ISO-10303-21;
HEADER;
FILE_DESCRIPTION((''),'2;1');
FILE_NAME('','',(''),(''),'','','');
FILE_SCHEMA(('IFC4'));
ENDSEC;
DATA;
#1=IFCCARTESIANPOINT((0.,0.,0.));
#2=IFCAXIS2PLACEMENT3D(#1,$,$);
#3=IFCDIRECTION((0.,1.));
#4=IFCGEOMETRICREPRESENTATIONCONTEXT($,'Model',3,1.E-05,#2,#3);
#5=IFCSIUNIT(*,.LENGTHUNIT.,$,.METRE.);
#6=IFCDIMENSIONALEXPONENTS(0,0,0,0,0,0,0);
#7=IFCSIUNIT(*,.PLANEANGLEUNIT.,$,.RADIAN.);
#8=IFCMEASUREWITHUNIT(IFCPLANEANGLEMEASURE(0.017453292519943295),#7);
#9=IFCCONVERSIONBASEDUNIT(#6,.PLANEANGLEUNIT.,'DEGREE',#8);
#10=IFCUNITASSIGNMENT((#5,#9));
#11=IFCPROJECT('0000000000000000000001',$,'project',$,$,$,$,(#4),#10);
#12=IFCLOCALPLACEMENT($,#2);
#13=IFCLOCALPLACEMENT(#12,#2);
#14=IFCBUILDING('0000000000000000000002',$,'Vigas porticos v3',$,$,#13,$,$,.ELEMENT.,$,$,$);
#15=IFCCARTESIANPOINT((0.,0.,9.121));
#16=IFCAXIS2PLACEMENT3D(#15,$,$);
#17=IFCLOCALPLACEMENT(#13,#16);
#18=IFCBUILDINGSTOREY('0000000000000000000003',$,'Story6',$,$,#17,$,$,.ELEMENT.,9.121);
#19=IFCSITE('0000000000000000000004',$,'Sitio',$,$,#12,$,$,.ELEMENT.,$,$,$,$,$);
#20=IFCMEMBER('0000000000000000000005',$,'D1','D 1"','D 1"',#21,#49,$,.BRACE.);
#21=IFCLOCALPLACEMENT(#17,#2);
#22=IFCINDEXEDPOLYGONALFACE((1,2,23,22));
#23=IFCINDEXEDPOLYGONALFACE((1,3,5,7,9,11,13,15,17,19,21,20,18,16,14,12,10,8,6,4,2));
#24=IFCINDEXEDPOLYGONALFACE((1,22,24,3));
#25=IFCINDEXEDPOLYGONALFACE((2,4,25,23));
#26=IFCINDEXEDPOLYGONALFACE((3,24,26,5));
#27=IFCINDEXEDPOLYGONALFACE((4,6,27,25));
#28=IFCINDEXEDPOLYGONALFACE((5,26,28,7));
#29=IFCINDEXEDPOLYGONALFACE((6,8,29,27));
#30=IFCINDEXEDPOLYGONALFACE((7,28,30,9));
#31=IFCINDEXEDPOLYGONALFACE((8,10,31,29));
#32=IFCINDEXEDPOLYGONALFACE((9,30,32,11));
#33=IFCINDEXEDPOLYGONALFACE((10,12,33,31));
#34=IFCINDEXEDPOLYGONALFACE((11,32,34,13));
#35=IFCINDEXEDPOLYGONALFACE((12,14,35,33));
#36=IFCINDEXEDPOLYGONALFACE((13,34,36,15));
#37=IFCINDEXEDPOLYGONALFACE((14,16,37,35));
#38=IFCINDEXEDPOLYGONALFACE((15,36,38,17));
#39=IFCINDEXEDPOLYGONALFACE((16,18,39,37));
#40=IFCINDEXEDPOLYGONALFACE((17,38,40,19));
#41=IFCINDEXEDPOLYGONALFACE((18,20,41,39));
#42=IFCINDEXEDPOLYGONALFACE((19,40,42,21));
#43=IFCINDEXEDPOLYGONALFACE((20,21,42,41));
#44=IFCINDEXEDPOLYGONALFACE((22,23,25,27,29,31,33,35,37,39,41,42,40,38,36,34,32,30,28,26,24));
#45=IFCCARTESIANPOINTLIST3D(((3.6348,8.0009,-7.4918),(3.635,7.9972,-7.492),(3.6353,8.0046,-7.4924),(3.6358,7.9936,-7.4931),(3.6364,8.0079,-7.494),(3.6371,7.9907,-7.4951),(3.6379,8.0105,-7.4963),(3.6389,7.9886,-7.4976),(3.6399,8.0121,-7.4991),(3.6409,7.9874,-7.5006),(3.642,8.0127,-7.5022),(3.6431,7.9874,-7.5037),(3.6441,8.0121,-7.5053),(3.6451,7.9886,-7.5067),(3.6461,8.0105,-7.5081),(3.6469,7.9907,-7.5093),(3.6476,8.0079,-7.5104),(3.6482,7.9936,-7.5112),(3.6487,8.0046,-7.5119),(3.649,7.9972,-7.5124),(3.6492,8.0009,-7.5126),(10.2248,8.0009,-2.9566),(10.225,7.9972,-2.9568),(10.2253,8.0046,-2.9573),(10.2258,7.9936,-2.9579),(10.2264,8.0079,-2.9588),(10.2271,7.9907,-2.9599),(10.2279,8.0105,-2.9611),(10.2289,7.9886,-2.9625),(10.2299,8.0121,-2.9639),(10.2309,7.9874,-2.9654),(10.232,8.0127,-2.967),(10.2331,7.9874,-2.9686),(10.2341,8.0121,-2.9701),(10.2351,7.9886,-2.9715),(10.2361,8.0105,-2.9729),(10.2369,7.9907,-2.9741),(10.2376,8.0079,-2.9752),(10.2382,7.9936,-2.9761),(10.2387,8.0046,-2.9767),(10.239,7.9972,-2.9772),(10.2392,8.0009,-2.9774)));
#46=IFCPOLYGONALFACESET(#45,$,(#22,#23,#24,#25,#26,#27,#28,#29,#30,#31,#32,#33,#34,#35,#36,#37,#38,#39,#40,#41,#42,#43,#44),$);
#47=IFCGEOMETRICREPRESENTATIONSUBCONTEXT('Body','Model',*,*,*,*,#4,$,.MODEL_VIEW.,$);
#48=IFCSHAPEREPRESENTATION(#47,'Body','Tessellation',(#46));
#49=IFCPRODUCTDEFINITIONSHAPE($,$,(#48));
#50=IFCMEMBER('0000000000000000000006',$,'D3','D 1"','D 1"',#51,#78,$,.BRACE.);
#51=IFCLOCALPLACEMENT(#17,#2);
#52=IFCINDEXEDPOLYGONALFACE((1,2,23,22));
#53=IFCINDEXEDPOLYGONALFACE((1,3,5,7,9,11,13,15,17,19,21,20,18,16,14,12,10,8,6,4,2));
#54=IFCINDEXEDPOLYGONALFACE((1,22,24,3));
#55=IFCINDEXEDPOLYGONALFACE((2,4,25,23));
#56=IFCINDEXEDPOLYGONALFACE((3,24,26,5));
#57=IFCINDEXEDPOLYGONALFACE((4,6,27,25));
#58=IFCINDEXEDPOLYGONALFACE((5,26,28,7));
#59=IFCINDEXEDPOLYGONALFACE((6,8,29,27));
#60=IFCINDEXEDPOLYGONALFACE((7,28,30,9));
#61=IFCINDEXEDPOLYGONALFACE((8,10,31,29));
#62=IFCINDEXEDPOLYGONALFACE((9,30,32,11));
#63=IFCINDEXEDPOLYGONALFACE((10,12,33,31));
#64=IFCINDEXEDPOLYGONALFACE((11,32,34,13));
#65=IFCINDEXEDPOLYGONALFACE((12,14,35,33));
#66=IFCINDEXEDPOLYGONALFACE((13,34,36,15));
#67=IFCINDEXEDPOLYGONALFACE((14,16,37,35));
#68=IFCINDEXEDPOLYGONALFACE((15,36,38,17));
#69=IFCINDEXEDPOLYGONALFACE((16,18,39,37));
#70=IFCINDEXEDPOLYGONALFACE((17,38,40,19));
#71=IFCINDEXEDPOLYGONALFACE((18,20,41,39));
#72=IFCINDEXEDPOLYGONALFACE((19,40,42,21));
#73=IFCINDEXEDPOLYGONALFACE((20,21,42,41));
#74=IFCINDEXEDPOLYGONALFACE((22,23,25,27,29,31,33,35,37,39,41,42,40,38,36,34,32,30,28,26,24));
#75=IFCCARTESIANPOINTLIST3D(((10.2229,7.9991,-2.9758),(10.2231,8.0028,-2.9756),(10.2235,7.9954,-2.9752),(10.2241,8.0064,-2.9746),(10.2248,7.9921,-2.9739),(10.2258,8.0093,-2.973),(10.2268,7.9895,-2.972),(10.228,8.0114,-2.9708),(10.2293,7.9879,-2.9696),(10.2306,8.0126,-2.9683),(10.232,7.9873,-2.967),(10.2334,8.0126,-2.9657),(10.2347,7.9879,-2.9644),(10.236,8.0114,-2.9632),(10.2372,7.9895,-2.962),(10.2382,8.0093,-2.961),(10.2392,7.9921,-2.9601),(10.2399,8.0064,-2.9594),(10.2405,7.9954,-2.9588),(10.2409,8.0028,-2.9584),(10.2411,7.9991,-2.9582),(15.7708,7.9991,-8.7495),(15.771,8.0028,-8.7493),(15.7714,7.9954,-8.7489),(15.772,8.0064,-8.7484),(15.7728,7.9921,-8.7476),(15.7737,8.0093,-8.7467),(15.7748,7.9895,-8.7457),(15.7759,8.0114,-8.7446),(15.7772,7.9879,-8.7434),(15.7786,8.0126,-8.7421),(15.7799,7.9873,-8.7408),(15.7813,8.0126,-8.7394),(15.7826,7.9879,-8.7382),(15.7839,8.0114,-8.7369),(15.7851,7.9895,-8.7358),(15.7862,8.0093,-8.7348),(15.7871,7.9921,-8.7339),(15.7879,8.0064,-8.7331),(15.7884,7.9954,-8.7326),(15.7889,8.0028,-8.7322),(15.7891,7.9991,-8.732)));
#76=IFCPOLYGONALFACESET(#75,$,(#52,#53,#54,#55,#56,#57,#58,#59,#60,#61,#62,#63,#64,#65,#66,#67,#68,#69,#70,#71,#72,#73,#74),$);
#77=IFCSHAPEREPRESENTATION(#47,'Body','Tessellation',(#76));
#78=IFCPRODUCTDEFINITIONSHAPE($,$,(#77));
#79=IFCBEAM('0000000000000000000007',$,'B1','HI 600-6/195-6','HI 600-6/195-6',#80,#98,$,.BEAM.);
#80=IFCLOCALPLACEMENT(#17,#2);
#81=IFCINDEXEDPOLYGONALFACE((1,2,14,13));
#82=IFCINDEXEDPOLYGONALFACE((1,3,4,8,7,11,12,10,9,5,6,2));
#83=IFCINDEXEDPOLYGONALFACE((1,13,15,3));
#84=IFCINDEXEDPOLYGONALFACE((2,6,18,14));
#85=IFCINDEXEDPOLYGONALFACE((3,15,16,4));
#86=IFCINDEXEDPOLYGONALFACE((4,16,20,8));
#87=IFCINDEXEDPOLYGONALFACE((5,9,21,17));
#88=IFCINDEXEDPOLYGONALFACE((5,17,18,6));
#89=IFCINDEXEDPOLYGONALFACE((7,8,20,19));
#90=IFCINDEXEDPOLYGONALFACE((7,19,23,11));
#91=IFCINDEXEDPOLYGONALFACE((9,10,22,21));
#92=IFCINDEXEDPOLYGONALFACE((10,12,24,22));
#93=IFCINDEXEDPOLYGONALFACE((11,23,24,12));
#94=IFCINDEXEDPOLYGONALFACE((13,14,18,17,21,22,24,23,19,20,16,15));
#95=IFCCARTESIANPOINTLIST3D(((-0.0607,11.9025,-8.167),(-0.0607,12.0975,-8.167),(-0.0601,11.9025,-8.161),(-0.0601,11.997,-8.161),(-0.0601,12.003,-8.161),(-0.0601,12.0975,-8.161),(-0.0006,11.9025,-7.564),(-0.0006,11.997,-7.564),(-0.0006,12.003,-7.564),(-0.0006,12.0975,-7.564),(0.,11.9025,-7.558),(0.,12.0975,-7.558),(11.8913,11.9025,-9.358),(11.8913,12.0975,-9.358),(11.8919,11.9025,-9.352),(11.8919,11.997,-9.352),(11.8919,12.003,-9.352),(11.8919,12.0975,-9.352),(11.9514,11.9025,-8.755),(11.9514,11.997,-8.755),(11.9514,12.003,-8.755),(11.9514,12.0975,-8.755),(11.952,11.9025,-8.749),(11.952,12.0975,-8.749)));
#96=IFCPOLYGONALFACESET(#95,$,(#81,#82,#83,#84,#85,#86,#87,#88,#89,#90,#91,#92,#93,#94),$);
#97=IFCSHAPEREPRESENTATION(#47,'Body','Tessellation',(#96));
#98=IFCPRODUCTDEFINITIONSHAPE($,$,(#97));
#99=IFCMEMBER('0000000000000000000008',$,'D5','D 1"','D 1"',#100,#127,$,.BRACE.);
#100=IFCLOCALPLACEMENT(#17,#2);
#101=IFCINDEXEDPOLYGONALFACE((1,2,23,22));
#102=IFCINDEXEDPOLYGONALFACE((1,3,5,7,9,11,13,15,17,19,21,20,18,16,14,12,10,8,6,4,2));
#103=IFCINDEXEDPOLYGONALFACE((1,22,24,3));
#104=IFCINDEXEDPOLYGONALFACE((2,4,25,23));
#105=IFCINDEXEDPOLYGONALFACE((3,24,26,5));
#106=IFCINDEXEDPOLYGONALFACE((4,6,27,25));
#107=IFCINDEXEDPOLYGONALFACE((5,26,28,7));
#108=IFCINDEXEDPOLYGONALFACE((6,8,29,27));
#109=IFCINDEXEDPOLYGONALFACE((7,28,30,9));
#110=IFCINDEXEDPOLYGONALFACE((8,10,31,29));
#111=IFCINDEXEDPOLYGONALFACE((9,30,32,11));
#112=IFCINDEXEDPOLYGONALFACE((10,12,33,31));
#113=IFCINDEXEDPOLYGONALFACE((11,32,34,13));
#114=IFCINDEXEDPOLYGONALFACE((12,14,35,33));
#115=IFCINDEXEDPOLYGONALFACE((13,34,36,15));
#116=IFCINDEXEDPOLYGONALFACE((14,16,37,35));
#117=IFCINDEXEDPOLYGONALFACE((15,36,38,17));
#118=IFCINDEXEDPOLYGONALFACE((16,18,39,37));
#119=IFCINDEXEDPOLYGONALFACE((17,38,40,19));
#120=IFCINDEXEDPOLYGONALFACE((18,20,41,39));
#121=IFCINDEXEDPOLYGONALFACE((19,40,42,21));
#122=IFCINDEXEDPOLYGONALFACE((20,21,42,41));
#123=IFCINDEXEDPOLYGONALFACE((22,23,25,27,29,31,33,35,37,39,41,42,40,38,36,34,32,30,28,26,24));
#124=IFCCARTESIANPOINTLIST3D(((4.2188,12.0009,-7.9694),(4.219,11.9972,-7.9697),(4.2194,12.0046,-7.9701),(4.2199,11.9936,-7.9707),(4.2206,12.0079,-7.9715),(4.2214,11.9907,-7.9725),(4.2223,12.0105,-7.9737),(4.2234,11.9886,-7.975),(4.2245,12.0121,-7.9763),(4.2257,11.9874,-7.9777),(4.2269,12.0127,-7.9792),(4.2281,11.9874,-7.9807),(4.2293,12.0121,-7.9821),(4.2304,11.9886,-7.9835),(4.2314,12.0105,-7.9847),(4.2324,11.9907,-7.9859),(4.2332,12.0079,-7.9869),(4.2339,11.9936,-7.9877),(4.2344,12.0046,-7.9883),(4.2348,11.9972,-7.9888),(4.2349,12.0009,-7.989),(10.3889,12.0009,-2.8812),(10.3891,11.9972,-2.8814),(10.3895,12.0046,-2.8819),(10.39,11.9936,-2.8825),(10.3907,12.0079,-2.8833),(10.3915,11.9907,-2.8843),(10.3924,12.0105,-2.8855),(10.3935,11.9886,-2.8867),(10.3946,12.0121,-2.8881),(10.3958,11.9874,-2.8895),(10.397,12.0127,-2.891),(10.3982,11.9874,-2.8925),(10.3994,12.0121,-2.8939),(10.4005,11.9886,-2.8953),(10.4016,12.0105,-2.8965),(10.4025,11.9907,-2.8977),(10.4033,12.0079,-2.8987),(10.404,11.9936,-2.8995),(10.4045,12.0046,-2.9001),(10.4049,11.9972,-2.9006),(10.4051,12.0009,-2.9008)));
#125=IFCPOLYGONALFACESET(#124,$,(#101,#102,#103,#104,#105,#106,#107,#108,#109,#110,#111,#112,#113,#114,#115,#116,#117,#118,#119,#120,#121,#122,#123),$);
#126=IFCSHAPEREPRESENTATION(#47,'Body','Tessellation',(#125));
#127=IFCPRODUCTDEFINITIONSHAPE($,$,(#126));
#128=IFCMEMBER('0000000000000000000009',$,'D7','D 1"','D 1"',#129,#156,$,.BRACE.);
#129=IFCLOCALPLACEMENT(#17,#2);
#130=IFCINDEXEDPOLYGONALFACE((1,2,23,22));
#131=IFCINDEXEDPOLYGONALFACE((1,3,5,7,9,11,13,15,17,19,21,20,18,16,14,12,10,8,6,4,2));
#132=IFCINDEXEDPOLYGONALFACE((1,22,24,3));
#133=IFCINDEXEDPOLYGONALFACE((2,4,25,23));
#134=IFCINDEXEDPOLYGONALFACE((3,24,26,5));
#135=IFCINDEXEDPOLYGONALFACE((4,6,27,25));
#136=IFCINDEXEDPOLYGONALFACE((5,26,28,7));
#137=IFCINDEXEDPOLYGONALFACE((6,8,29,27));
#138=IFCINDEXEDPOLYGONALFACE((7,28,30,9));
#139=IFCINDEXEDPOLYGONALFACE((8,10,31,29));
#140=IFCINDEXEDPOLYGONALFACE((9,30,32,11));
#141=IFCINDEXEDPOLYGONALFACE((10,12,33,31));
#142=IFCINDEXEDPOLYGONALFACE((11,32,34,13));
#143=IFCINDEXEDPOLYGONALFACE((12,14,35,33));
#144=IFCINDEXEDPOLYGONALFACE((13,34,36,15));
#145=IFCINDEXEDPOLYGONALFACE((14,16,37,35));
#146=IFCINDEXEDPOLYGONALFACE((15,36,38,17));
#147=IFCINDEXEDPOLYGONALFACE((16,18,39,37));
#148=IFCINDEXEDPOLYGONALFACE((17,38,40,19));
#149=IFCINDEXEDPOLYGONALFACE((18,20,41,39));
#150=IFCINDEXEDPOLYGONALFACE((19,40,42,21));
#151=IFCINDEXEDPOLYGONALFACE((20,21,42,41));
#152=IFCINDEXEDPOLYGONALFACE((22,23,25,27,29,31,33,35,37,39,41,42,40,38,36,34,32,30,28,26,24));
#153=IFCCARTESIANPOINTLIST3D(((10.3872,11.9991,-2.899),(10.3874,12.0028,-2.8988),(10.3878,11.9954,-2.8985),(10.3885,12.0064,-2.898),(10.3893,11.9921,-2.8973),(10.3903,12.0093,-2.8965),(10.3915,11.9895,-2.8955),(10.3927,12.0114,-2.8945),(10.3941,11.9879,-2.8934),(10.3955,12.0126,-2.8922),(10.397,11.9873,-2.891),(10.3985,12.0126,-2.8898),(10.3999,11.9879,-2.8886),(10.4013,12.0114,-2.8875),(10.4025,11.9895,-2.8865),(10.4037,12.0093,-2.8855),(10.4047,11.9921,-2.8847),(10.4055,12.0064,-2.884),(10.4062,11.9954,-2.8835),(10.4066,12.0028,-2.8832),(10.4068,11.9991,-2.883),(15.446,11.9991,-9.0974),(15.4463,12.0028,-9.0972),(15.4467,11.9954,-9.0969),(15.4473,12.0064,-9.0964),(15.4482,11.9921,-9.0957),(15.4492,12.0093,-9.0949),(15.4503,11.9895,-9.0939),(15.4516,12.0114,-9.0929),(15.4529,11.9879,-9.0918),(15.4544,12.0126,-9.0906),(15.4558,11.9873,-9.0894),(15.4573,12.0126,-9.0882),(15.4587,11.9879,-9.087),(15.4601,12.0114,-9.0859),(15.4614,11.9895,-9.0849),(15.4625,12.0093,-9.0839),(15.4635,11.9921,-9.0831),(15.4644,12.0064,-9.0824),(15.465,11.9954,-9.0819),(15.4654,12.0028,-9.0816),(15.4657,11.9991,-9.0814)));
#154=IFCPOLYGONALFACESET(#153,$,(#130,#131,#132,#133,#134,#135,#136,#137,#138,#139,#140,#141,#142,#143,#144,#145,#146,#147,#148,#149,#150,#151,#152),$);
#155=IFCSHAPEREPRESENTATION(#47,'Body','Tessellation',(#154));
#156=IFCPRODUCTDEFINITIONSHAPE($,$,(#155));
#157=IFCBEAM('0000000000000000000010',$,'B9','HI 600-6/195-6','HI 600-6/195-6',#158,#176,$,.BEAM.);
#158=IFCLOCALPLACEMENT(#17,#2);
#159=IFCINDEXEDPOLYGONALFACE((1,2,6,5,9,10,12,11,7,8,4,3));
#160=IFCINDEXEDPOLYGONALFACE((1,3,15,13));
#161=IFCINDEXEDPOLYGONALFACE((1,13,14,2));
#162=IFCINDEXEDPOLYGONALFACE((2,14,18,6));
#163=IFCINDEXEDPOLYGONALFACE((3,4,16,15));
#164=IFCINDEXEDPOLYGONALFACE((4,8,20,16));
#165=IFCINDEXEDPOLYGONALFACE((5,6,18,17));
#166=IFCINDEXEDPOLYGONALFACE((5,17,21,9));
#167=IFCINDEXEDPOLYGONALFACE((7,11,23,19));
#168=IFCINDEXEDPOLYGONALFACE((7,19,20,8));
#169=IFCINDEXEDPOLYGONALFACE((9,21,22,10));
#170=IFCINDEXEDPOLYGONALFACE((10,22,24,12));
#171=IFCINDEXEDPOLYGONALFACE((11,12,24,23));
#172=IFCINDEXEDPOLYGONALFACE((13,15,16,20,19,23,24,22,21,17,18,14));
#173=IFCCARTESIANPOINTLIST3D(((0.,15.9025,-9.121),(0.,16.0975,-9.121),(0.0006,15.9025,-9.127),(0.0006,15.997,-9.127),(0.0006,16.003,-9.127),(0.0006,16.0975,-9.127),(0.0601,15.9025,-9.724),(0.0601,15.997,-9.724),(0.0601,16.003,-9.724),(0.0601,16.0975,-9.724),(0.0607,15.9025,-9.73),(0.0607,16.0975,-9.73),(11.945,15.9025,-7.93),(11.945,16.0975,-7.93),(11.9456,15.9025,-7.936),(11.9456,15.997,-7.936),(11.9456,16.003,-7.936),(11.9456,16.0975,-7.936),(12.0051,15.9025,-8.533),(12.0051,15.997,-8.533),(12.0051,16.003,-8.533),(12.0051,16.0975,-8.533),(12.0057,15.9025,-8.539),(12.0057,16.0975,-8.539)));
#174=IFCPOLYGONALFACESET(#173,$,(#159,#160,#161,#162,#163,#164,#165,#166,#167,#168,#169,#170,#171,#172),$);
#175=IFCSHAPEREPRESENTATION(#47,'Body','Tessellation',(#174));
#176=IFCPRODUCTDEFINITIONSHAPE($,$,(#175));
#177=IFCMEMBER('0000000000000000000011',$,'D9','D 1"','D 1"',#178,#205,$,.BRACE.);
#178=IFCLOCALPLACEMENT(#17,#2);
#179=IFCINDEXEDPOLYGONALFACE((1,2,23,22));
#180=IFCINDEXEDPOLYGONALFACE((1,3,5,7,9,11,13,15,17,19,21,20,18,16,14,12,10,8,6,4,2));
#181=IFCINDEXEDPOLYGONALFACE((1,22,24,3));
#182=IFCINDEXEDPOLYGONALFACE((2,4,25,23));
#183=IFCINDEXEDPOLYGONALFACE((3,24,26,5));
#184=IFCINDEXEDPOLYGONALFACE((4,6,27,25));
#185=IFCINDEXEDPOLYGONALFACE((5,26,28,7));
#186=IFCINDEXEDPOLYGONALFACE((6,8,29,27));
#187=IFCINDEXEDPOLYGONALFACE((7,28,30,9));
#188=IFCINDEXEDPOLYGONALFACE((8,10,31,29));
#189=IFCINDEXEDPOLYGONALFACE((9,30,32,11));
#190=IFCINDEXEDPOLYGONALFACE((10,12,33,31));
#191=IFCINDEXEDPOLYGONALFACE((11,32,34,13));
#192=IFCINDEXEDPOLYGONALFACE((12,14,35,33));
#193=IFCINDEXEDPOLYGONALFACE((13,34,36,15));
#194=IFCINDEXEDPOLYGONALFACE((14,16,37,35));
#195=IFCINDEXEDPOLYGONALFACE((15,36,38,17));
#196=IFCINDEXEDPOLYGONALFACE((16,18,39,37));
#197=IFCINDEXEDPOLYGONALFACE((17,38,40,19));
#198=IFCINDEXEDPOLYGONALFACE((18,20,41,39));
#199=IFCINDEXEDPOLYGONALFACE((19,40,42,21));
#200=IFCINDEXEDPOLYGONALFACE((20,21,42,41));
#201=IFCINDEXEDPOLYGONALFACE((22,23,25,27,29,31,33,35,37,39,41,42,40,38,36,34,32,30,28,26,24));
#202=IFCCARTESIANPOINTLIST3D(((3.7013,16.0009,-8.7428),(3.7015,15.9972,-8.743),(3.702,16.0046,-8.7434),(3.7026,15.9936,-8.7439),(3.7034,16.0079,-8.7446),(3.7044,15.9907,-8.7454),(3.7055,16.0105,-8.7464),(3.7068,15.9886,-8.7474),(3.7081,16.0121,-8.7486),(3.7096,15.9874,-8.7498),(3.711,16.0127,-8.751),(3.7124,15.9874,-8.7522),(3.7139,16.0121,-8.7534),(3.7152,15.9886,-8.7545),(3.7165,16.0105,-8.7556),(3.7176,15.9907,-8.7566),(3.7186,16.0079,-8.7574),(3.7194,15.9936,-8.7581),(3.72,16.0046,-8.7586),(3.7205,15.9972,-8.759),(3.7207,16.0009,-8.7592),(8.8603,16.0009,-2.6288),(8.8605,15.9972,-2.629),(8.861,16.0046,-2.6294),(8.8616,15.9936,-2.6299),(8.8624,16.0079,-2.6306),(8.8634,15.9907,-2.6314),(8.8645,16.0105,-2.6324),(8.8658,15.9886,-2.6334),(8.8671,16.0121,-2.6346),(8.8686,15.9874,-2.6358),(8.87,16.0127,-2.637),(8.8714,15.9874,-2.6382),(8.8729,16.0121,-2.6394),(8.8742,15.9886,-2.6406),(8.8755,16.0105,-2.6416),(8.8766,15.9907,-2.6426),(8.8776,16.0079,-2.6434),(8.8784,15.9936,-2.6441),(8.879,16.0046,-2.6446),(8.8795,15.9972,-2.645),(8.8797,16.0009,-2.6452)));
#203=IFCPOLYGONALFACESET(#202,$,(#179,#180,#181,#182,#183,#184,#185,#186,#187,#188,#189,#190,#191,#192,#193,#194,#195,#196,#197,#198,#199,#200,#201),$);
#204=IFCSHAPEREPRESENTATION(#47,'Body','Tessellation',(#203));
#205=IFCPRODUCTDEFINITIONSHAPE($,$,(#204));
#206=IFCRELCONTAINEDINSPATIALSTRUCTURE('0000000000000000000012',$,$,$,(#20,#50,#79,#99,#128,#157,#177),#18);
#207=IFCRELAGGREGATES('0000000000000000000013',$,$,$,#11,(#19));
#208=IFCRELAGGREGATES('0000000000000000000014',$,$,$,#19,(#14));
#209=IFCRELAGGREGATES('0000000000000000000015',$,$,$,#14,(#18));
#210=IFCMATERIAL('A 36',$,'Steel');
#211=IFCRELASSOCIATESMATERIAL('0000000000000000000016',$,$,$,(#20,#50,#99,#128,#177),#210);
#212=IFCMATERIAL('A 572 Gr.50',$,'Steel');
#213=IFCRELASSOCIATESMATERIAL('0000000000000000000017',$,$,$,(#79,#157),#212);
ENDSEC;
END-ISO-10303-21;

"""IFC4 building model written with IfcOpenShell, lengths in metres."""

from ifc_helpers import new_model, entity, si_unit, converted_unit, direction, frame, origin, place, context, subcontext, project, spatial, circle, i_section, extrude, material, element, save


model = new_model("IFC4")

# Units and contexts
model_context = context("Model", 3, precision=1e-05, world=origin(), true_north=direction((0.0, 1.0)))
body_context = subcontext(model_context, "Body", "Model", "MODEL_VIEW")
ifc_project = project(units=[si_unit("LENGTHUNIT", "METRE"), converted_unit("PLANEANGLEUNIT", "DEGREE", entity("IfcPlaneAngleMeasure", 0.017453292519943295), si_unit("PLANEANGLEUNIT", "RADIAN"), dimensions=[0, 0, 0, 0, 0, 0, 0])], contexts=[model_context])

# Site, building, storey
site_placement = place(None, origin())
site = spatial("IfcSite", under=ifc_project, at=site_placement, Name="Sitio", CompositionType="ELEMENT")
building_placement = place(site_placement, origin())
building = spatial("IfcBuilding", under=site, at=building_placement, Name="Vigas porticos v3", CompositionType="ELEMENT")
storey_placement = place(building_placement, frame((0.0, 0.0, 9.121)))
storey = spatial("IfcBuildingStorey", under=building, at=storey_placement, Name="Story6", CompositionType="ELEMENT", Elevation=9.121)

# Shared definitions
ifc_material_1 = material(Name="A 572 Gr.50", Category="Steel")

# Shared definitions
ifc_material_2 = material(Name="A 36", Category="Steel")

# Members
member_1_placement = place(storey_placement, frame((3.642, 8.0, -7.5022), z_axis=(0.823776, 0.0, 0.566916), x_axis=(0.0, 1.0, 0.0)))
element("IfcMember", 1, at=member_1_placement, inside=storey, material=ifc_material_2, Name="D1", Description="D 1\"", ObjectType="D 1\"", PredefinedType="BRACE", context=body_context, shape_type="SweptSolid", body=[
    extrude(circle(Radius=0.0127), origin(), (0.0, 0.0, 1.0), 7.9997),
])
member_2_placement = place(storey_placement, frame((15.7799, 8.0, -8.7408), z_axis=(-0.692864, 0.0, 0.721068), x_axis=(0.0, -1.0, 0.0)))
element("IfcMember", 2, at=member_2_placement, inside=storey, material=ifc_material_2, Name="D3", Description="D 1\"", ObjectType="D 1\"", PredefinedType="BRACE", context=body_context, shape_type="SweptSolid", body=[
    extrude(circle(Radius=0.0127), origin(), (0.0, 0.0, 1.0), 8.0072),
])

# Beam
beam_1_placement = place(storey_placement, frame((11.952, 12.0, -8.749), z_axis=(-0.995072, 0.0, 0.099158), x_axis=(0.0, -1.0, 0.0)))
element("IfcBeam", 3, at=beam_1_placement, inside=storey, material=ifc_material_1, Name="B1", Description="HI 600-6/195-6", ObjectType="HI 600-6/195-6", PredefinedType="BEAM", context=body_context, shape_type="SweptSolid", body=[
    extrude(i_section(OverallWidth=0.195, OverallDepth=0.612, WebThickness=0.006, FlangeThickness=0.006), frame((0.0, -0.306, 0.0)), (0.0, 0.0, 1.0), 12.0112),
])

# Members
member_3_placement = place(storey_placement, frame((4.2269, 12.0, -7.9792), z_axis=(0.771505, 0.0, 0.636223), x_axis=(0.0, 1.0, 0.0)))
element("IfcMember", 4, at=member_3_placement, inside=storey, material=ifc_material_2, Name="D5", Description="D 1\"", ObjectType="D 1\"", PredefinedType="BRACE", context=body_context, shape_type="SweptSolid", body=[
    extrude(circle(Radius=0.0127), origin(), (0.0, 0.0, 1.0), 7.9975),
])
member_4_placement = place(storey_placement, frame((15.4558, 12.0, -9.0894), z_axis=(-0.632296, 0.0, 0.774727), x_axis=(0.0, -1.0, 0.0)))
element("IfcMember", 5, at=member_4_placement, inside=storey, material=ifc_material_2, Name="D7", Description="D 1\"", ObjectType="D 1\"", PredefinedType="BRACE", context=body_context, shape_type="SweptSolid", body=[
    extrude(circle(Radius=0.0127), origin(), (0.0, 0.0, 1.0), 8.0008),
])

# Beam
beam_2_placement = place(storey_placement, frame((0.0, 16.0, -9.121), z_axis=(0.995066, 0.0, 0.099215), x_axis=(0.0, 1.0, 0.0)))
element("IfcBeam", 6, at=beam_2_placement, inside=storey, material=ifc_material_1, Name="B9", Description="HI 600-6/195-6", ObjectType="HI 600-6/195-6", PredefinedType="BEAM", context=body_context, shape_type="SweptSolid", body=[
    extrude(i_section(OverallWidth=0.195, OverallDepth=0.612, WebThickness=0.006, FlangeThickness=0.006), frame((0.0, -0.306, 0.0)), (0.0, 0.0, 1.0), 12.0042),
])

# Member
member_5_placement = place(storey_placement, frame((3.711, 16.0, -8.751), z_axis=(0.644895, 0.0, 0.764271), x_axis=(0.0, 1.0, 0.0)))
element("IfcMember", 7, at=member_5_placement, inside=storey, material=ifc_material_2, Name="D9", Description="D 1\"", ObjectType="D 1\"", PredefinedType="BRACE", context=body_context, shape_type="SweptSolid", body=[
    extrude(circle(Radius=0.0127), origin(), (0.0, 0.0, 1.0), 7.9998),
])

save(model, "model.ifc")
